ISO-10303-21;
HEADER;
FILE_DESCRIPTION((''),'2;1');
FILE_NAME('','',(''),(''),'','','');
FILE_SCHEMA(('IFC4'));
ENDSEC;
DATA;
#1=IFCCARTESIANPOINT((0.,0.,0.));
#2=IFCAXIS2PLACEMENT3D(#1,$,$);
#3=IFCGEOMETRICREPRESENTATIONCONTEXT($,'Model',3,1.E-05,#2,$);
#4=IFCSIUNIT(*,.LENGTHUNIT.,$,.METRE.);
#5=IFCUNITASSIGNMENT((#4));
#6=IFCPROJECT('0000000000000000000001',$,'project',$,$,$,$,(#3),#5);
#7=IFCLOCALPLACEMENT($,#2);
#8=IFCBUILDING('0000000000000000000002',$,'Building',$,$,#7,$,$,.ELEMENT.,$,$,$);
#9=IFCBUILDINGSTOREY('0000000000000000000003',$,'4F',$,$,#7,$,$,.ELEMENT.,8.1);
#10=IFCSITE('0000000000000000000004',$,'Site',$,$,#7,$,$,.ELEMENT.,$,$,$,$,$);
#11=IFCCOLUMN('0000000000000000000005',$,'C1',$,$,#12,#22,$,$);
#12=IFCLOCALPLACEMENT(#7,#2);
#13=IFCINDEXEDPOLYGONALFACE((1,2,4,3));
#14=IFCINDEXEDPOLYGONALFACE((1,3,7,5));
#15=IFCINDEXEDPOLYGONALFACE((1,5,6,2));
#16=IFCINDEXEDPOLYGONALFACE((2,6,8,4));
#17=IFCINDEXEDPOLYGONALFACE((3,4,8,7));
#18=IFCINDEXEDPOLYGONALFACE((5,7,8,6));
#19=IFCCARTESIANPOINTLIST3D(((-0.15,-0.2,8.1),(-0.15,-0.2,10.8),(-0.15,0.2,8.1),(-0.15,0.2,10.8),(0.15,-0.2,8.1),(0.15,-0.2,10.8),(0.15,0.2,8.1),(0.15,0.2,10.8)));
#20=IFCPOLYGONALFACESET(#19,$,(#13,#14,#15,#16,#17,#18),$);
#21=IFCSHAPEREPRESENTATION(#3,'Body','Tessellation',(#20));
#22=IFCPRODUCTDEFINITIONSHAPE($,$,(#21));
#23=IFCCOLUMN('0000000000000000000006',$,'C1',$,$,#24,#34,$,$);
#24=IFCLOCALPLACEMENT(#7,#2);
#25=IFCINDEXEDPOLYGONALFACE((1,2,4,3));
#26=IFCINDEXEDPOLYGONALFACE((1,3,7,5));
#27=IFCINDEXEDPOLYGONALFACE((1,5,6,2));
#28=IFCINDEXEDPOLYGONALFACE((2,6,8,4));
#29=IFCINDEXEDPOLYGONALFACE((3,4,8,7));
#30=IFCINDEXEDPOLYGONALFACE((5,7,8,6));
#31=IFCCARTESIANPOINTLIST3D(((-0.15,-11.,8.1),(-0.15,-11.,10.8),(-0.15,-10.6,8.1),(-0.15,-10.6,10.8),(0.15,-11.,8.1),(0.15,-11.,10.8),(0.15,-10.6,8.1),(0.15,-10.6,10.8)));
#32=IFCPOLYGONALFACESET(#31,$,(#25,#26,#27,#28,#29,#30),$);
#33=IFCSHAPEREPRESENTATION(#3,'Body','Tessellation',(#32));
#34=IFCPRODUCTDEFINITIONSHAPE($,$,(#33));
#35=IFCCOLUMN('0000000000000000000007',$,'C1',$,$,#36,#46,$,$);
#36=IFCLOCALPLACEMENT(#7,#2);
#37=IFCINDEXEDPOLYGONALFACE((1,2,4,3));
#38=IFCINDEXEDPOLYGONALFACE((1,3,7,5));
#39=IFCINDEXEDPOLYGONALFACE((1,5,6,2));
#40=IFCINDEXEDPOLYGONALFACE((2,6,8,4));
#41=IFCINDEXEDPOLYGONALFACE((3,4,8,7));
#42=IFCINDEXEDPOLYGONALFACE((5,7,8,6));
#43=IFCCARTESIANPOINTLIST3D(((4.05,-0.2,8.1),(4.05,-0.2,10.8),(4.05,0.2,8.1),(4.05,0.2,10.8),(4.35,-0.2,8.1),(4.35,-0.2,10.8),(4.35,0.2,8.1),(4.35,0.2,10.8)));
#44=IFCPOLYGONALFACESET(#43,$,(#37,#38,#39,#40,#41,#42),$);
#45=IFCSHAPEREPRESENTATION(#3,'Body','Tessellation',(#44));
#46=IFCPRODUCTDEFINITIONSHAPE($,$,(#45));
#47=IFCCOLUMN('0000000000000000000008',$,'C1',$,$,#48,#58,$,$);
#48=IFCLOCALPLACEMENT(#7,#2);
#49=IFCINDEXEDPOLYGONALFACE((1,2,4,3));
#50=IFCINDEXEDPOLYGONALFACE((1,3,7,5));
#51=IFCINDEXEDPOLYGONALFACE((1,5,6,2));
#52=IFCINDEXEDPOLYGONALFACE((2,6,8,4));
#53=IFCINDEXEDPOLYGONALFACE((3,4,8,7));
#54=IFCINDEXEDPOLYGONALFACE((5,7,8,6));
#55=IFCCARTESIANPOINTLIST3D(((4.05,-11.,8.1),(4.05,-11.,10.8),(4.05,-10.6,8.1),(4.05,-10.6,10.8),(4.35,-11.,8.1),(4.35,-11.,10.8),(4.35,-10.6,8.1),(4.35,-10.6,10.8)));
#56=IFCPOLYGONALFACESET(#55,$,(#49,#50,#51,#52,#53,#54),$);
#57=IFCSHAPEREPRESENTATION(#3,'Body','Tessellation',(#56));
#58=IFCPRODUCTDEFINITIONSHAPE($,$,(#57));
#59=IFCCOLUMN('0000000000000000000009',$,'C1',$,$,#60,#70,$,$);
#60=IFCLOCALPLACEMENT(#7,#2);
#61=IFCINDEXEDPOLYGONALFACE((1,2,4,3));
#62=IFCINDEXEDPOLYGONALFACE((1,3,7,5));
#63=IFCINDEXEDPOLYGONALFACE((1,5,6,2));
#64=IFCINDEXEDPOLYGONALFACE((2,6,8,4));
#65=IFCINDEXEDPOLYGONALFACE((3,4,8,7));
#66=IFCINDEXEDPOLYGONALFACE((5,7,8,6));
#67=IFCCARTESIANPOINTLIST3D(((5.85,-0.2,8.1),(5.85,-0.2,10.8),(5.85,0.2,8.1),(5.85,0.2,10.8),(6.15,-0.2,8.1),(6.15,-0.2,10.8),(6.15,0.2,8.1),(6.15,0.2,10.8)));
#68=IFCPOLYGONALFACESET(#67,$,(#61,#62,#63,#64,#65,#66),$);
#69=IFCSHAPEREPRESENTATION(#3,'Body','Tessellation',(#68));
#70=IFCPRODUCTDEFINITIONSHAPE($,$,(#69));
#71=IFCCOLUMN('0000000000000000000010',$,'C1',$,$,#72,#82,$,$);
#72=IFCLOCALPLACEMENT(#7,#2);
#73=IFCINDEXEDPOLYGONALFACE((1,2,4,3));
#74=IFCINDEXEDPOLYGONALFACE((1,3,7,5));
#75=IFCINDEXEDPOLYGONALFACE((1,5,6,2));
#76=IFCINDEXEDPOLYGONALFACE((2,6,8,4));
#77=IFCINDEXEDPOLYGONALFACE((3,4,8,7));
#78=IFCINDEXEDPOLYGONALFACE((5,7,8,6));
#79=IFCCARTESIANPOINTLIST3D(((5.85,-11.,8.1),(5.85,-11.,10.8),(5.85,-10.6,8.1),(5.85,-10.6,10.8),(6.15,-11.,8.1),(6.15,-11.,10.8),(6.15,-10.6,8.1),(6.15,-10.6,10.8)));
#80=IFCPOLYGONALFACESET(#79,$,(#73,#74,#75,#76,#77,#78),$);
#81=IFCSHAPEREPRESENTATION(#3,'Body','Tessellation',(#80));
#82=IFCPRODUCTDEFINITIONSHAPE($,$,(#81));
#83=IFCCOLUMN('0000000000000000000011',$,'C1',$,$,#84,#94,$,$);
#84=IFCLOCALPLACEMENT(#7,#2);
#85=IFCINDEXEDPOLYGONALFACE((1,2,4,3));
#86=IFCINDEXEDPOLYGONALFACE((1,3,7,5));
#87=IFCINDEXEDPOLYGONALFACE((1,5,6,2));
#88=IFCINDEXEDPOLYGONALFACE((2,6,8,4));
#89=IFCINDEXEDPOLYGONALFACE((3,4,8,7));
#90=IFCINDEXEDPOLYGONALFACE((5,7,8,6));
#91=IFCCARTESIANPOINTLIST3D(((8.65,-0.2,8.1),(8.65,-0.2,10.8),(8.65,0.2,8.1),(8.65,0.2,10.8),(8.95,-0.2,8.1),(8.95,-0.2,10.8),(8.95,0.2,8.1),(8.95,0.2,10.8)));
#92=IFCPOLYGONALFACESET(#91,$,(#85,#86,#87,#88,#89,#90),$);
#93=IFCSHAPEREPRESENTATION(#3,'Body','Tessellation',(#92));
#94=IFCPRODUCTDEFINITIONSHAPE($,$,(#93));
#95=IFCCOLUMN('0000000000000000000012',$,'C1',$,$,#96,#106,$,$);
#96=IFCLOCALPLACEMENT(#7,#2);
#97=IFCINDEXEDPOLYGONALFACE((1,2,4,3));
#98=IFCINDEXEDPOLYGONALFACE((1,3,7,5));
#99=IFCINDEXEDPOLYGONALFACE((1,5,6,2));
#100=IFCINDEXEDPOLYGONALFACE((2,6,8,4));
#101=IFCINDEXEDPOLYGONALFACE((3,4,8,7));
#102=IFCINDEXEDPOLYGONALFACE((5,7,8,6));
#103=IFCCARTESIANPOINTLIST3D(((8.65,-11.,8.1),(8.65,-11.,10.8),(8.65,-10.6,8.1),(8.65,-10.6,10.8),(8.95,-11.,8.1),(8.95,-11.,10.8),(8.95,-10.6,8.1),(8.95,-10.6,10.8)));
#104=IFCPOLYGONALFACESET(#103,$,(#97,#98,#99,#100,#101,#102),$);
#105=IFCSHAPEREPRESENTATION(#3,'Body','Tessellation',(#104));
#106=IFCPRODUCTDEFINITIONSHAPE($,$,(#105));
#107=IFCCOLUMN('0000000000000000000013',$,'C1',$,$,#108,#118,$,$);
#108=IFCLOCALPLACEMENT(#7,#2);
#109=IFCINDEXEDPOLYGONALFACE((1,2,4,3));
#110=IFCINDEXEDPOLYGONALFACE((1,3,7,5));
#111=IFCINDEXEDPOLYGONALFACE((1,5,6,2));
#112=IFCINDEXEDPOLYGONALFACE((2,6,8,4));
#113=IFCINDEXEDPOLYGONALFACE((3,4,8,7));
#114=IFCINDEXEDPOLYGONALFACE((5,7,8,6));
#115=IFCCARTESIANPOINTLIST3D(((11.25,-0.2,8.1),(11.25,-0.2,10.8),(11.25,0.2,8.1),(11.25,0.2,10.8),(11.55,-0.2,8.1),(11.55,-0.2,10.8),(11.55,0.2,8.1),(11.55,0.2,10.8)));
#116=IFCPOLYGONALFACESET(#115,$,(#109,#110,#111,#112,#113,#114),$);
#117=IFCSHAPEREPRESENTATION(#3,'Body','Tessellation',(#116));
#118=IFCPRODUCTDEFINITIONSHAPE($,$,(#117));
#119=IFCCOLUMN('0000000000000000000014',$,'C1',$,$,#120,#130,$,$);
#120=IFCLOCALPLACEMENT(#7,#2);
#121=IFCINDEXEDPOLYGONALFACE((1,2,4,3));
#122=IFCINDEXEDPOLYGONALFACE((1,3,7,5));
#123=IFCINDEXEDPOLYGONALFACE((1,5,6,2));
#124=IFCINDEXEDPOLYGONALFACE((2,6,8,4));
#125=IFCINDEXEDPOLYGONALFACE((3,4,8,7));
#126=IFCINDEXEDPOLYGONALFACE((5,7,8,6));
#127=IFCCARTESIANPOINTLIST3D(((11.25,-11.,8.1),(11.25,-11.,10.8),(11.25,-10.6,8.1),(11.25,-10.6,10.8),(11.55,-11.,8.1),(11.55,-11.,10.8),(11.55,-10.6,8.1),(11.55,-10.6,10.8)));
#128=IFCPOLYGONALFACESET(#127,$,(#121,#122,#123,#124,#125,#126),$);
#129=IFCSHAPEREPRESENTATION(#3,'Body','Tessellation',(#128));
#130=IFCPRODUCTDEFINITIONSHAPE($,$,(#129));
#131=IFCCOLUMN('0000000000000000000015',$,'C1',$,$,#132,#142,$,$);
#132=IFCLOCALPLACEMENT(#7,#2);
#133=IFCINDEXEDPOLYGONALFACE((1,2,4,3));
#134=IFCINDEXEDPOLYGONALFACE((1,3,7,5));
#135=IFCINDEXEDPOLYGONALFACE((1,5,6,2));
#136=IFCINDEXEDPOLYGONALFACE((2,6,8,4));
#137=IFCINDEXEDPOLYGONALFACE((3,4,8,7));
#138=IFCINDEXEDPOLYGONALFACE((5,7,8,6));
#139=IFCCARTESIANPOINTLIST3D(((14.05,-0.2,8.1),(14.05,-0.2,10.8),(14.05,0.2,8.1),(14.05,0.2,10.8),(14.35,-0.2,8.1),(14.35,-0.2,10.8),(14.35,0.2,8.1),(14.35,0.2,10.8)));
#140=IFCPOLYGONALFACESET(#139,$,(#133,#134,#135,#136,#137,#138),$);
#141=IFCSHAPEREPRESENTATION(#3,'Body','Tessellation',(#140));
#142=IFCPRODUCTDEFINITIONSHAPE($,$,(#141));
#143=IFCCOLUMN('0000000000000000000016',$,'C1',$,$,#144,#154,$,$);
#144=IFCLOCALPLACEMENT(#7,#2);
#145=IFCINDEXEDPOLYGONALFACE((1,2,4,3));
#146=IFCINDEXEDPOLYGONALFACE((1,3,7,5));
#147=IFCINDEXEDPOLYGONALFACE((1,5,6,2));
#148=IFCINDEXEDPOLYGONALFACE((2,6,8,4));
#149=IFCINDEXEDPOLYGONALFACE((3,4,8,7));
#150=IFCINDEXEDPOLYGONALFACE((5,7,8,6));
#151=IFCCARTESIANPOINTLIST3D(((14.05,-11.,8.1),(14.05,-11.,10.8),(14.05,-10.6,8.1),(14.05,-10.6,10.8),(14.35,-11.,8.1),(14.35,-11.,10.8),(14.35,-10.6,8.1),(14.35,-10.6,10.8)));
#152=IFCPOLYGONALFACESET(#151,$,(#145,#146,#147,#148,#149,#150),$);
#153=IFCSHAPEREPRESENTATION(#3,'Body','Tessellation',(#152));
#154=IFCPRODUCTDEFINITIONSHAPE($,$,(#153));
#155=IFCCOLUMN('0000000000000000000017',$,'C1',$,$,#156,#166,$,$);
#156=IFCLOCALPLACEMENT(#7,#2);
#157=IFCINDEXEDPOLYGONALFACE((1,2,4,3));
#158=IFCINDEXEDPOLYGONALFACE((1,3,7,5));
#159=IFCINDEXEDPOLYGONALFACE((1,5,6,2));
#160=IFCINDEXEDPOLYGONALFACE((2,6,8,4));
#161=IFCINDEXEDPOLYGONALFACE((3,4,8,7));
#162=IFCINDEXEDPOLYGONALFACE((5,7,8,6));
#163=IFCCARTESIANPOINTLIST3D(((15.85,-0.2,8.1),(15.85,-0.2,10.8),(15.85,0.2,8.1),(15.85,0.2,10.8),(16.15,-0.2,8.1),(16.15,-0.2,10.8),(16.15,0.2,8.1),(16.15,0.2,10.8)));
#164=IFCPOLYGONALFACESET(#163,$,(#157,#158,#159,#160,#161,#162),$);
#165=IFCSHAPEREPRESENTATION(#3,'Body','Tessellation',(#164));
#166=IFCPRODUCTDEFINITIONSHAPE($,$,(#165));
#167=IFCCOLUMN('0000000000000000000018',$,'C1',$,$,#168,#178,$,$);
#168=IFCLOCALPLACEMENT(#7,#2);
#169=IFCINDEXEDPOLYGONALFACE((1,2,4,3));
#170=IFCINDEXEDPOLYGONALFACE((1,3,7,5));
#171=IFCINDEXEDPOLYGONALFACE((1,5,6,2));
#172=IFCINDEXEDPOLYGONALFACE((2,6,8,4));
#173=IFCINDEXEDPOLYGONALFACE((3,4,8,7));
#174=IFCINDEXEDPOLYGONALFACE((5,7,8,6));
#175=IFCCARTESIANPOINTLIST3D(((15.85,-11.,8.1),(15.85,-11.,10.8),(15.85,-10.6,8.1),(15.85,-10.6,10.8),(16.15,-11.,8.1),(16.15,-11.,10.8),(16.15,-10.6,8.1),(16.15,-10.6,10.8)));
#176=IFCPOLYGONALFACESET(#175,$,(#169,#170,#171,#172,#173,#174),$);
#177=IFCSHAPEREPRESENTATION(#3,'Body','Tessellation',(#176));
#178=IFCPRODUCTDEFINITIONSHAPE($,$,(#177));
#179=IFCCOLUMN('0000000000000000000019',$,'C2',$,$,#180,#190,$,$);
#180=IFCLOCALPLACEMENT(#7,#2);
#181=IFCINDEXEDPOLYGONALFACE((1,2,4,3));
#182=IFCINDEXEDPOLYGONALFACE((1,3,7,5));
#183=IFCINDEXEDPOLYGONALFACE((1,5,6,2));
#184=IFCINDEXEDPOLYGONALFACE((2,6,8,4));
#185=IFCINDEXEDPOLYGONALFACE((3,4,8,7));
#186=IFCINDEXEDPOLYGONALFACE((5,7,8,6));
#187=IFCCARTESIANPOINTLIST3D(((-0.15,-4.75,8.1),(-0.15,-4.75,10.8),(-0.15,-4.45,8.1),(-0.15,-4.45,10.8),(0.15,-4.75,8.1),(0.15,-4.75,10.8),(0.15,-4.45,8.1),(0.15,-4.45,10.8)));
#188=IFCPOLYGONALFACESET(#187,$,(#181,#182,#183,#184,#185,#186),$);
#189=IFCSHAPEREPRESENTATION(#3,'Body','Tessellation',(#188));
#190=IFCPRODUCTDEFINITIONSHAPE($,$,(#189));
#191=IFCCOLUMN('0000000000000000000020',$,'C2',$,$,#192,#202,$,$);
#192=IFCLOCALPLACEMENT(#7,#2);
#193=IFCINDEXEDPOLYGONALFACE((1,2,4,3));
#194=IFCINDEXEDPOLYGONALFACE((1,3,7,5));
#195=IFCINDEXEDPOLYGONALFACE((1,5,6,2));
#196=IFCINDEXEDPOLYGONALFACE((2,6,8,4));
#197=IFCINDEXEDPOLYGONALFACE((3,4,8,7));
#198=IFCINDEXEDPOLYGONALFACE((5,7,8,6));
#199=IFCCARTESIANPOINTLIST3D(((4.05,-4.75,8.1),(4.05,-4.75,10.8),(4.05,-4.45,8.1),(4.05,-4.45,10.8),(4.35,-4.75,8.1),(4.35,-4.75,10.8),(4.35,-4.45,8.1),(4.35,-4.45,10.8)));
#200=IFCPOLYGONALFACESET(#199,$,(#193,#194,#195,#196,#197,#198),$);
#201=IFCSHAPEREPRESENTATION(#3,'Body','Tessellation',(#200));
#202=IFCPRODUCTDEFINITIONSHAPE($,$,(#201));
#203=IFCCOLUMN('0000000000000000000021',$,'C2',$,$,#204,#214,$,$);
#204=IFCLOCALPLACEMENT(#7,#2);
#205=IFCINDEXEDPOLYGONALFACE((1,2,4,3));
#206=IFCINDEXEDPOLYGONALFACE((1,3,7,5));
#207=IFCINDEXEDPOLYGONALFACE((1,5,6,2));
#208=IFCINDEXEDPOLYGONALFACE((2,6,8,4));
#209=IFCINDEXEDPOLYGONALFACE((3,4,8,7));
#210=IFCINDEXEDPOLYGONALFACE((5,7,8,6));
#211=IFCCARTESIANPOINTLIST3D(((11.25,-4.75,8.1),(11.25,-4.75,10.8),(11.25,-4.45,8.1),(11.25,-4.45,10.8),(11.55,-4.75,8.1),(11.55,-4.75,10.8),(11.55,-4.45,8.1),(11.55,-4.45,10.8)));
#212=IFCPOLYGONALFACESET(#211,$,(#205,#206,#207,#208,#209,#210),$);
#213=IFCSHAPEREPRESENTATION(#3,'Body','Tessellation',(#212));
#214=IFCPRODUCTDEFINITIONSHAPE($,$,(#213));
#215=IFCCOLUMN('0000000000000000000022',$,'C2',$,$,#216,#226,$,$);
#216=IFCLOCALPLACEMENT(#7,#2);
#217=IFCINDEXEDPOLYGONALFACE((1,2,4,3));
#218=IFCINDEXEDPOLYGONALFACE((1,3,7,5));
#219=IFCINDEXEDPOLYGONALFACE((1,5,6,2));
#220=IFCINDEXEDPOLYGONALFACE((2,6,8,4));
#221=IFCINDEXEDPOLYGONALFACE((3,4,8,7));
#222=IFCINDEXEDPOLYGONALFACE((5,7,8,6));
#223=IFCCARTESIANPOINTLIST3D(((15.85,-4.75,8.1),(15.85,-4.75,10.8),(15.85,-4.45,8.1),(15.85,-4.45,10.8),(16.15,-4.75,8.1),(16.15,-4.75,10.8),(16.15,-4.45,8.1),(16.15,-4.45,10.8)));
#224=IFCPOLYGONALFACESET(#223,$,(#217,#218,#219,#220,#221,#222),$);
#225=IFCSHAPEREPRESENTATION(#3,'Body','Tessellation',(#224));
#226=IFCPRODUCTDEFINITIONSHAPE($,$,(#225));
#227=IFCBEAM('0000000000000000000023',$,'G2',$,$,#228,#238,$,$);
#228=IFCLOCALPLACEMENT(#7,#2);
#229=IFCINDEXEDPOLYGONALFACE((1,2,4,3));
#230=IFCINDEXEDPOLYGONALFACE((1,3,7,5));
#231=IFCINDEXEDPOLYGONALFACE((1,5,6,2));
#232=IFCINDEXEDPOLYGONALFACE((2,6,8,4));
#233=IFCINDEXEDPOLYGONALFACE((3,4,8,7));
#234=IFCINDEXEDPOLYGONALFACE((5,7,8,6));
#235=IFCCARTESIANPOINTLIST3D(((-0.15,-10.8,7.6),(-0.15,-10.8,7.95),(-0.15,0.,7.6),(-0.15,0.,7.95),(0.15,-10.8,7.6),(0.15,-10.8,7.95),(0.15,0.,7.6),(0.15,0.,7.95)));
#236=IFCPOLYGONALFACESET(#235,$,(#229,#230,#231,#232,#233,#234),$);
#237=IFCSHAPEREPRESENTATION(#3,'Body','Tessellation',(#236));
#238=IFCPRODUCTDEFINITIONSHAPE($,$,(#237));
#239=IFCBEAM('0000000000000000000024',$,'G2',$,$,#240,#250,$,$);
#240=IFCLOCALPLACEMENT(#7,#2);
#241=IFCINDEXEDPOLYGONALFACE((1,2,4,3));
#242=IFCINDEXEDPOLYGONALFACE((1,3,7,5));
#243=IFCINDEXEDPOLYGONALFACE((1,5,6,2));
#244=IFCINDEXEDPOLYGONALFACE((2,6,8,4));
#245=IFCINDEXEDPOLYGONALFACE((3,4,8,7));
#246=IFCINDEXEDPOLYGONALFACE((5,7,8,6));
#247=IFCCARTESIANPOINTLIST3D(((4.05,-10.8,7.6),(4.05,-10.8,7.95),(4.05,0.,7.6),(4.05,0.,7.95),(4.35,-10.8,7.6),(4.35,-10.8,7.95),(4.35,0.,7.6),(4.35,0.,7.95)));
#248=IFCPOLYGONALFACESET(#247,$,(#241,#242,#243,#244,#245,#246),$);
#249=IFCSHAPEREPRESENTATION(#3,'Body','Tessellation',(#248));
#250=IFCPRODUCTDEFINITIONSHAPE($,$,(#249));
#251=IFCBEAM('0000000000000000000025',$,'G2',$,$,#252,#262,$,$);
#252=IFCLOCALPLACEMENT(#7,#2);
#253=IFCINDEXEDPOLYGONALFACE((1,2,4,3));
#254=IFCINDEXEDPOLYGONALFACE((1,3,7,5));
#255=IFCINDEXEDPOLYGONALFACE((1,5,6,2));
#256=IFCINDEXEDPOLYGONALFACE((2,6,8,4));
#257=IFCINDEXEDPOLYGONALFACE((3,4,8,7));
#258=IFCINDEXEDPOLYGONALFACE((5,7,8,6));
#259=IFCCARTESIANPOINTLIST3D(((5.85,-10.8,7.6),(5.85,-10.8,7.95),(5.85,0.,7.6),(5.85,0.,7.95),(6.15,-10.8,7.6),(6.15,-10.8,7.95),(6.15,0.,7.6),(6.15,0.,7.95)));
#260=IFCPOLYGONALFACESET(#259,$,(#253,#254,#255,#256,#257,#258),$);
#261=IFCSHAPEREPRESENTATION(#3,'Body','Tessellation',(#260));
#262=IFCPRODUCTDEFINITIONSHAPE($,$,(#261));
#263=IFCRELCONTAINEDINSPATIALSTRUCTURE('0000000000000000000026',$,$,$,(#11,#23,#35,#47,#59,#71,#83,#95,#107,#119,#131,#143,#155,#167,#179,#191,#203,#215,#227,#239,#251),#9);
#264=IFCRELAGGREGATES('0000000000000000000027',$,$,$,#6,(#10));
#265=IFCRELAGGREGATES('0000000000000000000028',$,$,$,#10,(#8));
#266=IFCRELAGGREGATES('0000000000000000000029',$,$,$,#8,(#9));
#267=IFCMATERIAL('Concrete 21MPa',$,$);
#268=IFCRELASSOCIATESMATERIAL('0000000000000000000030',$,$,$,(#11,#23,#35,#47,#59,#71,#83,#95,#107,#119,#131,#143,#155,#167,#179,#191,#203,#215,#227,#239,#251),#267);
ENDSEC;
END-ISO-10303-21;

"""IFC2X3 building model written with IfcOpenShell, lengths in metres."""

from ifc_helpers import new_model, si_unit, frame, origin, origin_2d, place, context, project, spatial, rectangle, extrude, material, element, save


model = new_model("IFC2X3")

# Units and contexts
model_context = context("Model", 3, precision=1e-05, world=origin())
ifc_project = project(units=[si_unit("LENGTHUNIT", "METRE")], contexts=[model_context])

# Site, building, storey
placement = place(None, origin())
site = spatial("IfcSite", under=ifc_project, at=placement, Name="Site", CompositionType="ELEMENT")
building = spatial("IfcBuilding", under=site, at=placement, Name="Building", CompositionType="ELEMENT")
storey = spatial("IfcBuildingStorey", under=building, at=placement, Name="4F", CompositionType="ELEMENT", Elevation=8.1)

# Columns
ifc_material = material(Name="Concrete 21MPa")
for number, where, name in (
    (1, (0.0, 0.0, 8.1), "C1"),
    (2, (0.0, -10.8, 8.1), "C1"),
    (3, (4.2, 0.0, 8.1), "C1"),
    (4, (4.2, -10.8, 8.1), "C1"),
    (5, (6.0, 0.0, 8.1), "C1"),
    (6, (6.0, -10.8, 8.1), "C1"),
    (7, (8.8, 0.0, 8.1), "C1"),
    (8, (8.8, -10.8, 8.1), "C1"),
    (9, (11.4, 0.0, 8.1), "C1"),
    (10, (11.4, -10.8, 8.1), "C1"),
    (11, (14.2, 0.0, 8.1), "C1"),
    (12, (14.2, -10.8, 8.1), "C1"),
    (13, (16.0, 0.0, 8.1), "C1"),
    (14, (16.0, -10.8, 8.1), "C1"),
):
    element("IfcColumn", number, at=place(None, frame(where)), inside=storey, material=ifc_material, Name=name, context=model_context, shape_type="SweptSolid", body=[
        extrude(rectangle(XDim=0.3, YDim=0.4, at=origin_2d()), origin(), (0.0, 0.0, 1.0), 2.7),
    ])
for number, where, name in (
    (15, (0.0, -4.6, 8.1), "C2"),
    (16, (4.2, -4.6, 8.1), "C2"),
    (17, (11.4, -4.6, 8.1), "C2"),
    (18, (16.0, -4.6, 8.1), "C2"),
):
    element("IfcColumn", number, at=place(None, frame(where)), inside=storey, material=ifc_material, Name=name, context=model_context, shape_type="SweptSolid", body=[
        extrude(rectangle(XDim=0.3, YDim=0.3, at=origin_2d()), origin(), (0.0, 0.0, 1.0), 2.7),
    ])

# Beams
for number, where, name in (
    (19, (0.0, -5.4, 7.6), "G2"),
    (20, (4.2, -5.4, 7.6), "G2"),
    (21, (6.0, -5.4, 7.6), "G2"),
):
    element("IfcBeam", number, at=place(None, frame(where)), inside=storey, material=ifc_material, Name=name, context=model_context, shape_type="SweptSolid", body=[
        extrude(rectangle(XDim=0.3, YDim=10.8, at=origin_2d()), origin(), (0.0, 0.0, 1.0), 0.35),
    ])

save(model, "model.ifc")
